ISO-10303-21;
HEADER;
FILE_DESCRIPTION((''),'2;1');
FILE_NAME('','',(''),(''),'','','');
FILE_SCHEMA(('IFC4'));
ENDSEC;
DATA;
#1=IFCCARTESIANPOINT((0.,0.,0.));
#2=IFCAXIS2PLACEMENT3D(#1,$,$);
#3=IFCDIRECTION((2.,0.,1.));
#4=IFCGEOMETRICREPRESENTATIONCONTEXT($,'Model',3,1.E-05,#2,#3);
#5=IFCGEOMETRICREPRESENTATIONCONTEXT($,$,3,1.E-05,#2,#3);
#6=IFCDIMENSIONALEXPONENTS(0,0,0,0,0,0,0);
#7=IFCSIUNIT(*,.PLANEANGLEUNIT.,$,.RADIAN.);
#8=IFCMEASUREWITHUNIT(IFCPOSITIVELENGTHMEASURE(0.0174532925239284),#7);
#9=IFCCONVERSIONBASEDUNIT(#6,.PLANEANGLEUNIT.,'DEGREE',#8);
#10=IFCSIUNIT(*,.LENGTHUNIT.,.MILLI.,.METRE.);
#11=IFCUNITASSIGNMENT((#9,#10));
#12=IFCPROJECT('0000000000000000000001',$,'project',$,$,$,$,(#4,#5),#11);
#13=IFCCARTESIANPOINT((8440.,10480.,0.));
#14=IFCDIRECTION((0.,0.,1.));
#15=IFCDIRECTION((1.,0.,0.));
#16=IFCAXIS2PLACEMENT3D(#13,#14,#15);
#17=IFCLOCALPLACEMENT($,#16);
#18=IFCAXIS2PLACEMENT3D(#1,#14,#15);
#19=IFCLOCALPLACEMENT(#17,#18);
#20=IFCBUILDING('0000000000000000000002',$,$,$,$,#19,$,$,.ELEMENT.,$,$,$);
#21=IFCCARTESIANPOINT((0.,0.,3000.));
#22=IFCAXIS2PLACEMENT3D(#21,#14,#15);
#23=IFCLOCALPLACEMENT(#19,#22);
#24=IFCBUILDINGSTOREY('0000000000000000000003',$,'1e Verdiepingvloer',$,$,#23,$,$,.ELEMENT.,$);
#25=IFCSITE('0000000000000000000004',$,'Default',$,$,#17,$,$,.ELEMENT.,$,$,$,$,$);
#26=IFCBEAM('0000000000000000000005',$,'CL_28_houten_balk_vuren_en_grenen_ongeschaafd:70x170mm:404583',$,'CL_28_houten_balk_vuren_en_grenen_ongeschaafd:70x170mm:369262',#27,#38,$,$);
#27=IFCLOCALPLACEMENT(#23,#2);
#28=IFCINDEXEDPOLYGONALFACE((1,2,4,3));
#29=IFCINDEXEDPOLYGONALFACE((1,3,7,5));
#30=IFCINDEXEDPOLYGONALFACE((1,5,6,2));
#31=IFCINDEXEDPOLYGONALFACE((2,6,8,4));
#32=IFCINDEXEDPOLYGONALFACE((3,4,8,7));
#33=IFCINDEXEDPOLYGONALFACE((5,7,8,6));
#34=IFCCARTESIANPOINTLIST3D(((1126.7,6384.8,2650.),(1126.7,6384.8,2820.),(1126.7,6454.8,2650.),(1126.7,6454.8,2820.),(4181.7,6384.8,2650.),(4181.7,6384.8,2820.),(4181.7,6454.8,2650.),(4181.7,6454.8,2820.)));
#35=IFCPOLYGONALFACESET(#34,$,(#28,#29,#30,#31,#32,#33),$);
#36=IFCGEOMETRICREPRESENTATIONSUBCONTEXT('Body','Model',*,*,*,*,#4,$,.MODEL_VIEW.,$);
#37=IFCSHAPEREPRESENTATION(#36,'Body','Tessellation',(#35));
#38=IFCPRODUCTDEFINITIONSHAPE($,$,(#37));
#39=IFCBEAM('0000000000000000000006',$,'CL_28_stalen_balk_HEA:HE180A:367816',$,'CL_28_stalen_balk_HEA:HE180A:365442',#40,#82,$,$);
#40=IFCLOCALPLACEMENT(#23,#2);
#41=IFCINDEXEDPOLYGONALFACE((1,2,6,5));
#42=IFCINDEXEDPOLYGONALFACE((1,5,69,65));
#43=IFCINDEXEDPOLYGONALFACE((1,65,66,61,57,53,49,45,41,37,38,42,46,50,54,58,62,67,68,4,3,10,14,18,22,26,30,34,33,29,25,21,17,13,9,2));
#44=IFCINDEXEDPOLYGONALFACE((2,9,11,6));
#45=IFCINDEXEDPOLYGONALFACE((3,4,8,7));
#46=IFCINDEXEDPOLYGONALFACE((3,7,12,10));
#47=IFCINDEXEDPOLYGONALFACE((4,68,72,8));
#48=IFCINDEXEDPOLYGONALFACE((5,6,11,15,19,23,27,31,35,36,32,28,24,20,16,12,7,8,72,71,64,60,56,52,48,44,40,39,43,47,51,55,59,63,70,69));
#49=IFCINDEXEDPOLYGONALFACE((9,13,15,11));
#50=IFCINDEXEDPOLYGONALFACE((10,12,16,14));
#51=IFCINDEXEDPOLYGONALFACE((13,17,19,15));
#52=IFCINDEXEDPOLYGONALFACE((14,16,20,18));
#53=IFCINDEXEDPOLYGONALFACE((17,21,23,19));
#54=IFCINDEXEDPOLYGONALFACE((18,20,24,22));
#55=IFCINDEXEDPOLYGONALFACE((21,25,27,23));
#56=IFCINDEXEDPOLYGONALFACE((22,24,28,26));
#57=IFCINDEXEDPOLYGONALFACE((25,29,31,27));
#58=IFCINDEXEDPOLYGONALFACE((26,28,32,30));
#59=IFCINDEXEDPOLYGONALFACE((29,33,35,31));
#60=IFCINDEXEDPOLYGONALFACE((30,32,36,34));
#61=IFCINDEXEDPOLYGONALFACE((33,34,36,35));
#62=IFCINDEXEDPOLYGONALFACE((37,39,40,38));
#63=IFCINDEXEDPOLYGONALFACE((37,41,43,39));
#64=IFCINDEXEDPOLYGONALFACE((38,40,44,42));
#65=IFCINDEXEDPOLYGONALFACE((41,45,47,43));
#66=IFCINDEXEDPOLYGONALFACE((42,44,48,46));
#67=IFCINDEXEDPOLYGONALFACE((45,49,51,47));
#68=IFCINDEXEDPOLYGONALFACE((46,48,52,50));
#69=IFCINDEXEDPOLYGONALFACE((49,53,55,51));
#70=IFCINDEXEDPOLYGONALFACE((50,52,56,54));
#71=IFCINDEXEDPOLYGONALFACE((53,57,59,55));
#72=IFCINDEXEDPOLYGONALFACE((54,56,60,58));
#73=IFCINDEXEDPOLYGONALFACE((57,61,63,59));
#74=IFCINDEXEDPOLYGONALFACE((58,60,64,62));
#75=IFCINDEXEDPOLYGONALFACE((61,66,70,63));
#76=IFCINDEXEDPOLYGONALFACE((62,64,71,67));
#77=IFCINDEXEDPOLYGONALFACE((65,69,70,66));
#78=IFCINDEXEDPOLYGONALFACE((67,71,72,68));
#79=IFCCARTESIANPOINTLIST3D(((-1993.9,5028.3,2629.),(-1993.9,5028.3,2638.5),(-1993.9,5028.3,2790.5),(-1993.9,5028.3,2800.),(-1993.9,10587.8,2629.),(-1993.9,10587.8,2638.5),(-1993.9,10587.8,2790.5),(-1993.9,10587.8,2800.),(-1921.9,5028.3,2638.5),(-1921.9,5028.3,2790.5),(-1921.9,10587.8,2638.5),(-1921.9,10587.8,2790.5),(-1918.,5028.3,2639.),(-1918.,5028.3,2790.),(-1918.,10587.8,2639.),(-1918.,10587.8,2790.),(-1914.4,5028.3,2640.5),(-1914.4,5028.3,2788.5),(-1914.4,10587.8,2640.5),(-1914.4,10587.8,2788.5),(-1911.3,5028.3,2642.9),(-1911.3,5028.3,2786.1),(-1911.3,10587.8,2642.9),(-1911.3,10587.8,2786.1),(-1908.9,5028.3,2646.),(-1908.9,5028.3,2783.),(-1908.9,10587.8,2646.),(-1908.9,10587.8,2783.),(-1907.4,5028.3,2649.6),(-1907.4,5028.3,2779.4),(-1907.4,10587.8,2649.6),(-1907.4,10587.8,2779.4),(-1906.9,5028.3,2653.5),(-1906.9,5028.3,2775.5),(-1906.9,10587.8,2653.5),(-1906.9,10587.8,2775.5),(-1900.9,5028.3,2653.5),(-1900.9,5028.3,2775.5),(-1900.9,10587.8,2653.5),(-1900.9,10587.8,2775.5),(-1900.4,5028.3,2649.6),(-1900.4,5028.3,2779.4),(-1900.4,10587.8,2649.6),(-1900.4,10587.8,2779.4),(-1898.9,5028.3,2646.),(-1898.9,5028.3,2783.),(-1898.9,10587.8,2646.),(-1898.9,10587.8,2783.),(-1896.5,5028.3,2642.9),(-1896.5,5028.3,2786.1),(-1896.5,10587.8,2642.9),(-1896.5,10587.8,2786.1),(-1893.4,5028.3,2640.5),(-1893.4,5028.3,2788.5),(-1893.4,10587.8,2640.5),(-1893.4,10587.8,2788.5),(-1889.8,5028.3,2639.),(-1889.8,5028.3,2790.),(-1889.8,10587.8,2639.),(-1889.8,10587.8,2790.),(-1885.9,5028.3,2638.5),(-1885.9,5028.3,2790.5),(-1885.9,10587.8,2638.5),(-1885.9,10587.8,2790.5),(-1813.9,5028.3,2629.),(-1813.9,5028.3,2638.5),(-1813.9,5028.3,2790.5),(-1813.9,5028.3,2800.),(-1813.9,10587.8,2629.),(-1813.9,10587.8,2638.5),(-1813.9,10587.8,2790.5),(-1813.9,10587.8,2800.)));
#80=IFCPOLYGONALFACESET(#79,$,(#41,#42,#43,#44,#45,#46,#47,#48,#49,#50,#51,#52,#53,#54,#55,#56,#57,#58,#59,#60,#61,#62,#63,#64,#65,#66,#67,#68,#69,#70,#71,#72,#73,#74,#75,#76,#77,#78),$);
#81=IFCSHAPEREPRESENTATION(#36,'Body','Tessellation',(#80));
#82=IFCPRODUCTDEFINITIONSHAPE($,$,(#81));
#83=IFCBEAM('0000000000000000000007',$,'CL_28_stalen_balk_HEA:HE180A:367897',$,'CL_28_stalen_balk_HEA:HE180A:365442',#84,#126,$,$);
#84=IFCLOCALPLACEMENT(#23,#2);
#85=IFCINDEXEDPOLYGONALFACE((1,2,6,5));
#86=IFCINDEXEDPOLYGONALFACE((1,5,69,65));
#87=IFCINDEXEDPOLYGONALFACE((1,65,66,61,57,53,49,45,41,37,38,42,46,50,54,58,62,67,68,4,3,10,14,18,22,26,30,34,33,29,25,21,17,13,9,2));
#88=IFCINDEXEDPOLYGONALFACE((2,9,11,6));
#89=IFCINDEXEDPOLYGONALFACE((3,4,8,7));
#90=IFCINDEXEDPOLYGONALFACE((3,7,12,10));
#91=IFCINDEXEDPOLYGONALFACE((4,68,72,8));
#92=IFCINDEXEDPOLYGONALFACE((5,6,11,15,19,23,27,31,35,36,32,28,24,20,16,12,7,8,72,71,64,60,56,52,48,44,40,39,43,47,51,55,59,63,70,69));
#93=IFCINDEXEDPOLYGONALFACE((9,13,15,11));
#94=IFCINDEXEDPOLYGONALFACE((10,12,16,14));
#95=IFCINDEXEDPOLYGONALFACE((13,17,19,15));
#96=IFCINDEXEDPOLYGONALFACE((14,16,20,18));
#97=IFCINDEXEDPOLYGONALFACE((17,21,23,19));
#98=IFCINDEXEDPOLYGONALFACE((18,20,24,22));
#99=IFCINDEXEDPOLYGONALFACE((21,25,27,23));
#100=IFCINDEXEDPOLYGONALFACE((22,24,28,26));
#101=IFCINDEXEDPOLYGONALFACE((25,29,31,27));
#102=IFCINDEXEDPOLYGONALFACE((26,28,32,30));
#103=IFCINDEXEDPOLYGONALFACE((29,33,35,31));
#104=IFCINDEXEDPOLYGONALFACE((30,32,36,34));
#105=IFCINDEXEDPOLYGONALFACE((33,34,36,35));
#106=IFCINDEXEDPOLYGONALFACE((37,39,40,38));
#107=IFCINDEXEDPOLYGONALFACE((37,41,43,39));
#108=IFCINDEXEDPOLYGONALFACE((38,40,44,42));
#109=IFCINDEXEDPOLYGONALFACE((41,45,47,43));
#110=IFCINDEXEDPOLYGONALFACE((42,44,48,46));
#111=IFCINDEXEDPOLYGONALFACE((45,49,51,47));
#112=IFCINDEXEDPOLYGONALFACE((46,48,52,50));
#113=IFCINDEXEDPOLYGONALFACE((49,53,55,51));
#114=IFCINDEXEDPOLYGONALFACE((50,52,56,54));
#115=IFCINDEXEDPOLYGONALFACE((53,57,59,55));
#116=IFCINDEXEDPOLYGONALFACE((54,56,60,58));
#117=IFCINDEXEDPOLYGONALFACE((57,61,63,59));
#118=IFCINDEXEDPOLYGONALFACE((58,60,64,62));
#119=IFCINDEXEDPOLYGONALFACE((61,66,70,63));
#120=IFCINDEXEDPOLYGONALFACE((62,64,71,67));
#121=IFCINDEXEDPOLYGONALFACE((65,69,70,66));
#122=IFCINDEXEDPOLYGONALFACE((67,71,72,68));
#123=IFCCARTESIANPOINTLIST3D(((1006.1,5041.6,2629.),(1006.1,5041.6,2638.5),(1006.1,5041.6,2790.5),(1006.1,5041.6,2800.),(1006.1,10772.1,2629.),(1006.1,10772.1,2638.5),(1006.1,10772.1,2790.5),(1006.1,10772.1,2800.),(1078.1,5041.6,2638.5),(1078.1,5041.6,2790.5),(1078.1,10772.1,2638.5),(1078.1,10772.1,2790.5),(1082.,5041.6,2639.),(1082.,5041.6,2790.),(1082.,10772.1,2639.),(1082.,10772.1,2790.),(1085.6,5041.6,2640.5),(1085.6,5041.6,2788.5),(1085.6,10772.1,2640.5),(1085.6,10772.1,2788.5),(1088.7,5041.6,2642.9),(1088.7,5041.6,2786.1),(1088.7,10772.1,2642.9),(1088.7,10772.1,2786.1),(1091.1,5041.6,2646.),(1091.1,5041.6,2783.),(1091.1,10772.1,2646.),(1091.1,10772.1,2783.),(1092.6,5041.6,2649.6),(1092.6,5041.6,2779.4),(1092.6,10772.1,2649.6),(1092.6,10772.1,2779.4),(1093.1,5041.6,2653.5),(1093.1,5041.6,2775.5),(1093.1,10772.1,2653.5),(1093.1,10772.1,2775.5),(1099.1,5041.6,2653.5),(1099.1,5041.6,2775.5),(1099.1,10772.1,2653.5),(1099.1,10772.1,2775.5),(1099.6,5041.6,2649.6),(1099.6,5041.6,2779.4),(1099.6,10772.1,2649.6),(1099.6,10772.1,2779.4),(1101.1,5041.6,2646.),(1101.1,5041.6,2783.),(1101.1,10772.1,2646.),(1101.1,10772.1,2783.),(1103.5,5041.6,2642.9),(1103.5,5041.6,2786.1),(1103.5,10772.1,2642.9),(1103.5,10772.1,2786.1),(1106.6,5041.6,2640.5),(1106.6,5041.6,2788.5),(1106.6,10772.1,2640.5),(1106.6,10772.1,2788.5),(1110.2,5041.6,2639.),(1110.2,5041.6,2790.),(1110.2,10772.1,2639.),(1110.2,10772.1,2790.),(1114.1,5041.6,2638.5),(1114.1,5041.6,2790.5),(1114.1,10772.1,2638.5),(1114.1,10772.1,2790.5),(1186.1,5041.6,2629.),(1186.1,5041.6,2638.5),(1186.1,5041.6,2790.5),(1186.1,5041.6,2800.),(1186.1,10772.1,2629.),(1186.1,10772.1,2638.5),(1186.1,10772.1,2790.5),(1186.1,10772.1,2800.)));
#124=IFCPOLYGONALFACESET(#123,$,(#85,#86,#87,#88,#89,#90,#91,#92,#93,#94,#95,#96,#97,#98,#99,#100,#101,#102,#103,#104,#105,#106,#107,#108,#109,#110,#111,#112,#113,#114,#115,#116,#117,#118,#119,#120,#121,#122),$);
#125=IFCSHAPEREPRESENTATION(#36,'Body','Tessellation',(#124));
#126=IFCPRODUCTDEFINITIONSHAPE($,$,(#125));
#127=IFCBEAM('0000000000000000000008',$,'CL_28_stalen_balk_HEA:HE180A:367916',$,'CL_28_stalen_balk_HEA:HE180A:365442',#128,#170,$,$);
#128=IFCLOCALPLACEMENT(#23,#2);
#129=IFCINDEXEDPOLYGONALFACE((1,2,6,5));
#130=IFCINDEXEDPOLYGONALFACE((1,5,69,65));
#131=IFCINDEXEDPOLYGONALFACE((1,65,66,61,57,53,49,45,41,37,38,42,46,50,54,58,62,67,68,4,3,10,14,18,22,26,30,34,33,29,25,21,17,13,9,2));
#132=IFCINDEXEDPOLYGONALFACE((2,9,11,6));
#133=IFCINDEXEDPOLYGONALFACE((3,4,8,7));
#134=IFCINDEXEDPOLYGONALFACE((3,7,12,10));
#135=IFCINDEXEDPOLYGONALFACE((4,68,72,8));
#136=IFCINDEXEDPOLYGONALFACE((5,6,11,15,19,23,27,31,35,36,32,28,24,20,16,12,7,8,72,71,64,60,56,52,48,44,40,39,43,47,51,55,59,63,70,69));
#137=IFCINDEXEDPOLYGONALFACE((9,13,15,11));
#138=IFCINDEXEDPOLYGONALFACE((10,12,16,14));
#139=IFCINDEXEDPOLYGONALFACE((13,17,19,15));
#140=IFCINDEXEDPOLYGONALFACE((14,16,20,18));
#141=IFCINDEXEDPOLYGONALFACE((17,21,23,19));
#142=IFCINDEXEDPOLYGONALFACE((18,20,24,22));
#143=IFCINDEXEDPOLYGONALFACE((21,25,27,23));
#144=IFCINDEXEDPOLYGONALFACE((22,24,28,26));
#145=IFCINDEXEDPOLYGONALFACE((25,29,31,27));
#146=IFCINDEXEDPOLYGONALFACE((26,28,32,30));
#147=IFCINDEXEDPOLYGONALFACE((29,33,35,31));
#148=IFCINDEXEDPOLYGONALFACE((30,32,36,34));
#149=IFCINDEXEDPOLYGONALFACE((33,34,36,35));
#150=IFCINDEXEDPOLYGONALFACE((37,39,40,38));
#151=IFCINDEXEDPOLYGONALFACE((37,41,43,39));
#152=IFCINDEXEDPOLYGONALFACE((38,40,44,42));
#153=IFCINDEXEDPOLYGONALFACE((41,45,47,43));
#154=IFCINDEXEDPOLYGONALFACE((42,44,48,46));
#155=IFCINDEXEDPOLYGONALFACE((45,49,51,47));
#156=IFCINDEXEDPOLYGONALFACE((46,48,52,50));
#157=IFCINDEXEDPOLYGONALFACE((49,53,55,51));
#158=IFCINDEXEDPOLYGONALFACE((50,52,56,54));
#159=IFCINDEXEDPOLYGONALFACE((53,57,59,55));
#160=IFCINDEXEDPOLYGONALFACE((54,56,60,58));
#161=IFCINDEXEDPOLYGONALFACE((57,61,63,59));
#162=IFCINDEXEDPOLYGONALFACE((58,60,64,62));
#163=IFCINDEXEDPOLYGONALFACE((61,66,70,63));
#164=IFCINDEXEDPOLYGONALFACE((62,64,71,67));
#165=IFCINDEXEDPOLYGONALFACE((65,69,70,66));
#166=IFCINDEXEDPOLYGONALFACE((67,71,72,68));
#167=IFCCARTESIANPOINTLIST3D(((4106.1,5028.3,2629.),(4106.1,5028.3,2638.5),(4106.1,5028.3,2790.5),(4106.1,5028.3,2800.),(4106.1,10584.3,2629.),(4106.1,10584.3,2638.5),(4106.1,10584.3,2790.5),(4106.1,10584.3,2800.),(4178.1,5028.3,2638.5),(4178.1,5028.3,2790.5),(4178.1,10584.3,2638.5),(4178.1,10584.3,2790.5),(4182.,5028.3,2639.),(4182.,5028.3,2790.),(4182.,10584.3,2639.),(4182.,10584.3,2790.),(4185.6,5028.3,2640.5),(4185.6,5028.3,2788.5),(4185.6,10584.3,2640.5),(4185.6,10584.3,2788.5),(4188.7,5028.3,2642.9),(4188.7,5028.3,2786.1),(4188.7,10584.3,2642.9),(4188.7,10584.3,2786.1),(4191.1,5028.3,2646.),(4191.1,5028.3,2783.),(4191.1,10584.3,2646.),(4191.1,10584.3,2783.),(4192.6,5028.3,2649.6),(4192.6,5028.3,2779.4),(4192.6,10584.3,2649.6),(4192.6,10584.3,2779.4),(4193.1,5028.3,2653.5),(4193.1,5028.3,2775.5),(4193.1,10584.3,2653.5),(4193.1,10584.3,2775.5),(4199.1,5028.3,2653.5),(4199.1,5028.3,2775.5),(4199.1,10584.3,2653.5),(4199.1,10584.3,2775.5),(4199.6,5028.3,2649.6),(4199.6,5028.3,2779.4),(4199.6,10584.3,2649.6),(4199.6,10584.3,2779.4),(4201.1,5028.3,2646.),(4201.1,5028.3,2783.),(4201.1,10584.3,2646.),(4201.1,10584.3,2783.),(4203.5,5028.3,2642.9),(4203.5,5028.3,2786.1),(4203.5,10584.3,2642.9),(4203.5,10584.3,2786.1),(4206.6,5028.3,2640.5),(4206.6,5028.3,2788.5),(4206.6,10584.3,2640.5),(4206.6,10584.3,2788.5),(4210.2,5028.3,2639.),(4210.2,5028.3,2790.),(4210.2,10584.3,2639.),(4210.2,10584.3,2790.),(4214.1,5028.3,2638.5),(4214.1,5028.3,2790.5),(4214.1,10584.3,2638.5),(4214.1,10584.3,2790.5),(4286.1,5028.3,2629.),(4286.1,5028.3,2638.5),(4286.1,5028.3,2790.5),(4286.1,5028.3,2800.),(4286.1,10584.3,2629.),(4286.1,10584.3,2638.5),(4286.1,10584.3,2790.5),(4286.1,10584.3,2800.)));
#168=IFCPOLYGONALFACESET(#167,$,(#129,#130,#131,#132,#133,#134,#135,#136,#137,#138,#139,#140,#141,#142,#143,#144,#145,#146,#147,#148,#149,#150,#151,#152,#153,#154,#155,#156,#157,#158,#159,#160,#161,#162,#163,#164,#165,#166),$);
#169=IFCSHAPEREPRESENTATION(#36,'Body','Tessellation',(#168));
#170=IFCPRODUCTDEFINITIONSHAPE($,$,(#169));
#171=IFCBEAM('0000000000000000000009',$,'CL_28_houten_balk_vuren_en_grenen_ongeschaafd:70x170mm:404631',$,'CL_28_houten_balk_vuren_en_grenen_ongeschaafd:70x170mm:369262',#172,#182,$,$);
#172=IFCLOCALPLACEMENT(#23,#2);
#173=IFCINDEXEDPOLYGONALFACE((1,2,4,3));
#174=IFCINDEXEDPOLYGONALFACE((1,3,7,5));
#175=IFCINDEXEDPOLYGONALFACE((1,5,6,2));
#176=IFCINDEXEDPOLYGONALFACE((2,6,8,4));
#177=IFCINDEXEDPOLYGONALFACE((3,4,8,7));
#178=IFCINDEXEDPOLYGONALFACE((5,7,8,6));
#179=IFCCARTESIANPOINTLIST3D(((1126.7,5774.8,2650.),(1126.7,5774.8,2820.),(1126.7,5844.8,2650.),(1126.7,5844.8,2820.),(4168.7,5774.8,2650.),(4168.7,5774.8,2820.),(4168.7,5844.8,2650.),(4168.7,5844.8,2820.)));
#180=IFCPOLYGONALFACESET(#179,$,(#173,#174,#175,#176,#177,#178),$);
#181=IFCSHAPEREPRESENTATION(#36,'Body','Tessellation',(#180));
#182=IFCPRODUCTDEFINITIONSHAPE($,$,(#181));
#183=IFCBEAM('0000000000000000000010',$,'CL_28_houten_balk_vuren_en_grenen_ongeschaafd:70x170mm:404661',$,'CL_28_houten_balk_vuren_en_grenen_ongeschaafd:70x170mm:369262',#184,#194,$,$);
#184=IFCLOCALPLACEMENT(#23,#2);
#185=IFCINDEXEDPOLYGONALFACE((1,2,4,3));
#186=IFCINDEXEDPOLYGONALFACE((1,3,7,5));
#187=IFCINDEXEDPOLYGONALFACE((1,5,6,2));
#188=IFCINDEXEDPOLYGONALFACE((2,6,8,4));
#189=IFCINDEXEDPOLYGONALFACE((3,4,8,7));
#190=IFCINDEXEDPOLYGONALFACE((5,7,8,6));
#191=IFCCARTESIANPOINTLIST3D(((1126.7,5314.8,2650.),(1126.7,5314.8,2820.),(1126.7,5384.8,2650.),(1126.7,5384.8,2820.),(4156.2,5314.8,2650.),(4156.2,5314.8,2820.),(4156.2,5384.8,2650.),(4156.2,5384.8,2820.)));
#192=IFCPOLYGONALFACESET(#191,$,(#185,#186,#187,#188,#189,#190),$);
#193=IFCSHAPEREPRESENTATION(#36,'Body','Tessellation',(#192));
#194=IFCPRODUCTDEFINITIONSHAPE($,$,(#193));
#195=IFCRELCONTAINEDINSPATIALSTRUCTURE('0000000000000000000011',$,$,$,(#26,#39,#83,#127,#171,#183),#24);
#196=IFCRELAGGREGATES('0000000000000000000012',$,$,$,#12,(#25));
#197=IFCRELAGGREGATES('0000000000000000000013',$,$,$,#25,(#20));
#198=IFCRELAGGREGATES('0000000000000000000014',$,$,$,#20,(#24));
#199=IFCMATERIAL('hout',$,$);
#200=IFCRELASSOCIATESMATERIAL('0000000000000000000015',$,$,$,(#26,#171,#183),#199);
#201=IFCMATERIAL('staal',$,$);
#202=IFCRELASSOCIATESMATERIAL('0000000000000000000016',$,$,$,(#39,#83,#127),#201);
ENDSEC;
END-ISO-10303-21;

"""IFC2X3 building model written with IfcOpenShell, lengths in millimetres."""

from ifc_helpers import new_model, entity, si_unit, converted_unit, direction, frame, frame_2d, origin, origin_with_axes, place, context, subcontext, project, spatial, rectangle, i_section, extrude, source, transform, mapped, material, element, save


model = new_model("IFC2X3")

# Units and contexts
model_context = context("Model", 3, precision=1e-05, world=origin(), true_north=direction((2.0, 0.0, 1.0)))
context_of_model = context(None, 3, precision=1e-05, world=origin(), true_north=direction((2.0, 0.0, 1.0)))
body_context = subcontext(model_context, "Body", "Model", "MODEL_VIEW")
ifc_project = project(units=[converted_unit("PLANEANGLEUNIT", "DEGREE", entity("IfcPositiveLengthMeasure", 0.0174532925239284), si_unit("PLANEANGLEUNIT", "RADIAN"), dimensions=[0, 0, 0, 0, 0, 0, 0]), si_unit("LENGTHUNIT", "METRE", prefix="MILLI")], contexts=[model_context, context_of_model])

# Site, building, storey
site_placement = place(None, frame((8440.0, 10480.0, 0.0), z_axis=(0.0, 0.0, 1.0), x_axis=(1.0, 0.0, 0.0)))
site = spatial("IfcSite", under=ifc_project, at=site_placement, Name="Default", CompositionType="ELEMENT")
building_placement = place(site_placement, origin_with_axes())
building = spatial("IfcBuilding", under=site, at=building_placement, CompositionType="ELEMENT")
storey_placement = place(building_placement, frame((0.0, 0.0, 3000.0), z_axis=(0.0, 0.0, 1.0), x_axis=(1.0, 0.0, 0.0)))
storey = spatial("IfcBuildingStorey", under=building, at=storey_placement, Name="1e Verdiepingvloer", CompositionType="ELEMENT")

# Beams
ifc_material_1 = material(Name="hout")
shared_shape_1 = source(origin(), body_context, "Body", "SweptSolid", [
    extrude(rectangle(XDim=170.0, YDim=70.0, at=frame_2d((0.0, 0.0), x_axis=(1.0, 0.0))), frame((155.6, 0.0, -85.0), z_axis=(1.0, 0.0, 0.0), x_axis=(0.0, 0.0, -1.0)), (0.0, 0.0, 1.0), 3055.0),
])
beam_1_placement = place(storey_placement, frame((971.1, 6419.8, 2820.0), z_axis=(0.0, 0.0, 1.0), x_axis=(1.0, 0.0, 0.0)))
element("IfcBeam", 1, at=beam_1_placement, inside=storey, material=ifc_material_1, Name="CL_28_houten_balk_vuren_en_grenen_ongeschaafd:70x170mm:404583", ObjectType="CL_28_houten_balk_vuren_en_grenen_ongeschaafd:70x170mm:369262", context=body_context, shape_type="MappedRepresentation", body=[
    mapped(shared_shape_1, transform((0.0, 0.0, 0.0))),
])
ifc_material_2 = material(Name="staal")
beam_2_placement = place(storey_placement, frame((-1903.9, 4959.8, 2800.0), z_axis=(0.0, 0.0, 1.0), x_axis=(0.0, 1.0, 0.0)))
element("IfcBeam", 2, at=beam_2_placement, inside=storey, material=ifc_material_2, Name="CL_28_stalen_balk_HEA:HE180A:367816", ObjectType="CL_28_stalen_balk_HEA:HE180A:365442", context=body_context, shape_type="SweptSolid", body=[
    extrude(i_section(OverallWidth=180.0, OverallDepth=171.0, WebThickness=6.0, FlangeThickness=9.5, FilletRadius=15.0, at=frame_2d((0.0, 0.0), x_axis=(0.0, 1.0))), frame((68.5, 0.0, -85.5), z_axis=(1.0, 0.0, 0.0), x_axis=(0.0, 0.0, -1.0)), (0.0, 0.0, 1.0), 5559.5),
])
beam_3_placement = place(storey_placement, frame((1096.1, 4916.8, 2800.0), z_axis=(0.0, 0.0, 1.0), x_axis=(0.0, 1.0, 0.0)))
element("IfcBeam", 3, at=beam_3_placement, inside=storey, material=ifc_material_2, Name="CL_28_stalen_balk_HEA:HE180A:367897", ObjectType="CL_28_stalen_balk_HEA:HE180A:365442", context=body_context, shape_type="SweptSolid", body=[
    extrude(i_section(OverallWidth=180.0, OverallDepth=171.0, WebThickness=6.0, FlangeThickness=9.5, FilletRadius=15.0, at=frame_2d((0.0, 0.0), x_axis=(0.0, 1.0))), frame((124.8, 0.0, -85.5), z_axis=(1.0, 0.0, 0.0), x_axis=(0.0, 0.0, -1.0)), (0.0, 0.0, 1.0), 5730.5),
])
beam_4_placement = place(storey_placement, frame((4196.1, 4959.8, 2800.0), z_axis=(0.0, 0.0, 1.0), x_axis=(0.0, 1.0, 0.0)))
element("IfcBeam", 4, at=beam_4_placement, inside=storey, material=ifc_material_2, Name="CL_28_stalen_balk_HEA:HE180A:367916", ObjectType="CL_28_stalen_balk_HEA:HE180A:365442", context=body_context, shape_type="SweptSolid", body=[
    extrude(i_section(OverallWidth=180.0, OverallDepth=171.0, WebThickness=6.0, FlangeThickness=9.5, FilletRadius=15.0, at=frame_2d((0.0, 0.0), x_axis=(0.0, 1.0))), frame((68.5, 0.0, -85.5), z_axis=(1.0, 0.0, 0.0), x_axis=(0.0, 0.0, -1.0)), (0.0, 0.0, 1.0), 5555.9),
])
beam_5_placement = place(storey_placement, frame((971.1, 5809.8, 2820.0), z_axis=(0.0, 0.0, 1.0), x_axis=(1.0, 0.0, 0.0)))
element("IfcBeam", 5, at=beam_5_placement, inside=storey, material=ifc_material_1, Name="CL_28_houten_balk_vuren_en_grenen_ongeschaafd:70x170mm:404631", ObjectType="CL_28_houten_balk_vuren_en_grenen_ongeschaafd:70x170mm:369262", context=body_context, shape_type="SweptSolid", body=[
    extrude(rectangle(XDim=170.0, YDim=70.0, at=frame_2d((0.0, 0.0), x_axis=(1.0, 0.0))), frame((155.6, 0.0, -85.0), z_axis=(1.0, 0.0, 0.0), x_axis=(0.0, 0.0, -1.0)), (0.0, 0.0, 1.0), 3042.0),
])
beam_6_placement = place(storey_placement, frame((971.1, 5349.8, 2820.0), z_axis=(0.0, 0.0, 1.0), x_axis=(1.0, 0.0, 0.0)))
element("IfcBeam", 6, at=beam_6_placement, inside=storey, material=ifc_material_1, Name="CL_28_houten_balk_vuren_en_grenen_ongeschaafd:70x170mm:404661", ObjectType="CL_28_houten_balk_vuren_en_grenen_ongeschaafd:70x170mm:369262", context=body_context, shape_type="SweptSolid", body=[
    extrude(rectangle(XDim=170.0, YDim=70.0, at=frame_2d((0.0, 0.0), x_axis=(1.0, 0.0))), frame((155.6, 0.0, -85.0), z_axis=(1.0, 0.0, 0.0), x_axis=(0.0, 0.0, -1.0)), (0.0, 0.0, 1.0), 3029.5),
])

save(model, "model.ifc")
